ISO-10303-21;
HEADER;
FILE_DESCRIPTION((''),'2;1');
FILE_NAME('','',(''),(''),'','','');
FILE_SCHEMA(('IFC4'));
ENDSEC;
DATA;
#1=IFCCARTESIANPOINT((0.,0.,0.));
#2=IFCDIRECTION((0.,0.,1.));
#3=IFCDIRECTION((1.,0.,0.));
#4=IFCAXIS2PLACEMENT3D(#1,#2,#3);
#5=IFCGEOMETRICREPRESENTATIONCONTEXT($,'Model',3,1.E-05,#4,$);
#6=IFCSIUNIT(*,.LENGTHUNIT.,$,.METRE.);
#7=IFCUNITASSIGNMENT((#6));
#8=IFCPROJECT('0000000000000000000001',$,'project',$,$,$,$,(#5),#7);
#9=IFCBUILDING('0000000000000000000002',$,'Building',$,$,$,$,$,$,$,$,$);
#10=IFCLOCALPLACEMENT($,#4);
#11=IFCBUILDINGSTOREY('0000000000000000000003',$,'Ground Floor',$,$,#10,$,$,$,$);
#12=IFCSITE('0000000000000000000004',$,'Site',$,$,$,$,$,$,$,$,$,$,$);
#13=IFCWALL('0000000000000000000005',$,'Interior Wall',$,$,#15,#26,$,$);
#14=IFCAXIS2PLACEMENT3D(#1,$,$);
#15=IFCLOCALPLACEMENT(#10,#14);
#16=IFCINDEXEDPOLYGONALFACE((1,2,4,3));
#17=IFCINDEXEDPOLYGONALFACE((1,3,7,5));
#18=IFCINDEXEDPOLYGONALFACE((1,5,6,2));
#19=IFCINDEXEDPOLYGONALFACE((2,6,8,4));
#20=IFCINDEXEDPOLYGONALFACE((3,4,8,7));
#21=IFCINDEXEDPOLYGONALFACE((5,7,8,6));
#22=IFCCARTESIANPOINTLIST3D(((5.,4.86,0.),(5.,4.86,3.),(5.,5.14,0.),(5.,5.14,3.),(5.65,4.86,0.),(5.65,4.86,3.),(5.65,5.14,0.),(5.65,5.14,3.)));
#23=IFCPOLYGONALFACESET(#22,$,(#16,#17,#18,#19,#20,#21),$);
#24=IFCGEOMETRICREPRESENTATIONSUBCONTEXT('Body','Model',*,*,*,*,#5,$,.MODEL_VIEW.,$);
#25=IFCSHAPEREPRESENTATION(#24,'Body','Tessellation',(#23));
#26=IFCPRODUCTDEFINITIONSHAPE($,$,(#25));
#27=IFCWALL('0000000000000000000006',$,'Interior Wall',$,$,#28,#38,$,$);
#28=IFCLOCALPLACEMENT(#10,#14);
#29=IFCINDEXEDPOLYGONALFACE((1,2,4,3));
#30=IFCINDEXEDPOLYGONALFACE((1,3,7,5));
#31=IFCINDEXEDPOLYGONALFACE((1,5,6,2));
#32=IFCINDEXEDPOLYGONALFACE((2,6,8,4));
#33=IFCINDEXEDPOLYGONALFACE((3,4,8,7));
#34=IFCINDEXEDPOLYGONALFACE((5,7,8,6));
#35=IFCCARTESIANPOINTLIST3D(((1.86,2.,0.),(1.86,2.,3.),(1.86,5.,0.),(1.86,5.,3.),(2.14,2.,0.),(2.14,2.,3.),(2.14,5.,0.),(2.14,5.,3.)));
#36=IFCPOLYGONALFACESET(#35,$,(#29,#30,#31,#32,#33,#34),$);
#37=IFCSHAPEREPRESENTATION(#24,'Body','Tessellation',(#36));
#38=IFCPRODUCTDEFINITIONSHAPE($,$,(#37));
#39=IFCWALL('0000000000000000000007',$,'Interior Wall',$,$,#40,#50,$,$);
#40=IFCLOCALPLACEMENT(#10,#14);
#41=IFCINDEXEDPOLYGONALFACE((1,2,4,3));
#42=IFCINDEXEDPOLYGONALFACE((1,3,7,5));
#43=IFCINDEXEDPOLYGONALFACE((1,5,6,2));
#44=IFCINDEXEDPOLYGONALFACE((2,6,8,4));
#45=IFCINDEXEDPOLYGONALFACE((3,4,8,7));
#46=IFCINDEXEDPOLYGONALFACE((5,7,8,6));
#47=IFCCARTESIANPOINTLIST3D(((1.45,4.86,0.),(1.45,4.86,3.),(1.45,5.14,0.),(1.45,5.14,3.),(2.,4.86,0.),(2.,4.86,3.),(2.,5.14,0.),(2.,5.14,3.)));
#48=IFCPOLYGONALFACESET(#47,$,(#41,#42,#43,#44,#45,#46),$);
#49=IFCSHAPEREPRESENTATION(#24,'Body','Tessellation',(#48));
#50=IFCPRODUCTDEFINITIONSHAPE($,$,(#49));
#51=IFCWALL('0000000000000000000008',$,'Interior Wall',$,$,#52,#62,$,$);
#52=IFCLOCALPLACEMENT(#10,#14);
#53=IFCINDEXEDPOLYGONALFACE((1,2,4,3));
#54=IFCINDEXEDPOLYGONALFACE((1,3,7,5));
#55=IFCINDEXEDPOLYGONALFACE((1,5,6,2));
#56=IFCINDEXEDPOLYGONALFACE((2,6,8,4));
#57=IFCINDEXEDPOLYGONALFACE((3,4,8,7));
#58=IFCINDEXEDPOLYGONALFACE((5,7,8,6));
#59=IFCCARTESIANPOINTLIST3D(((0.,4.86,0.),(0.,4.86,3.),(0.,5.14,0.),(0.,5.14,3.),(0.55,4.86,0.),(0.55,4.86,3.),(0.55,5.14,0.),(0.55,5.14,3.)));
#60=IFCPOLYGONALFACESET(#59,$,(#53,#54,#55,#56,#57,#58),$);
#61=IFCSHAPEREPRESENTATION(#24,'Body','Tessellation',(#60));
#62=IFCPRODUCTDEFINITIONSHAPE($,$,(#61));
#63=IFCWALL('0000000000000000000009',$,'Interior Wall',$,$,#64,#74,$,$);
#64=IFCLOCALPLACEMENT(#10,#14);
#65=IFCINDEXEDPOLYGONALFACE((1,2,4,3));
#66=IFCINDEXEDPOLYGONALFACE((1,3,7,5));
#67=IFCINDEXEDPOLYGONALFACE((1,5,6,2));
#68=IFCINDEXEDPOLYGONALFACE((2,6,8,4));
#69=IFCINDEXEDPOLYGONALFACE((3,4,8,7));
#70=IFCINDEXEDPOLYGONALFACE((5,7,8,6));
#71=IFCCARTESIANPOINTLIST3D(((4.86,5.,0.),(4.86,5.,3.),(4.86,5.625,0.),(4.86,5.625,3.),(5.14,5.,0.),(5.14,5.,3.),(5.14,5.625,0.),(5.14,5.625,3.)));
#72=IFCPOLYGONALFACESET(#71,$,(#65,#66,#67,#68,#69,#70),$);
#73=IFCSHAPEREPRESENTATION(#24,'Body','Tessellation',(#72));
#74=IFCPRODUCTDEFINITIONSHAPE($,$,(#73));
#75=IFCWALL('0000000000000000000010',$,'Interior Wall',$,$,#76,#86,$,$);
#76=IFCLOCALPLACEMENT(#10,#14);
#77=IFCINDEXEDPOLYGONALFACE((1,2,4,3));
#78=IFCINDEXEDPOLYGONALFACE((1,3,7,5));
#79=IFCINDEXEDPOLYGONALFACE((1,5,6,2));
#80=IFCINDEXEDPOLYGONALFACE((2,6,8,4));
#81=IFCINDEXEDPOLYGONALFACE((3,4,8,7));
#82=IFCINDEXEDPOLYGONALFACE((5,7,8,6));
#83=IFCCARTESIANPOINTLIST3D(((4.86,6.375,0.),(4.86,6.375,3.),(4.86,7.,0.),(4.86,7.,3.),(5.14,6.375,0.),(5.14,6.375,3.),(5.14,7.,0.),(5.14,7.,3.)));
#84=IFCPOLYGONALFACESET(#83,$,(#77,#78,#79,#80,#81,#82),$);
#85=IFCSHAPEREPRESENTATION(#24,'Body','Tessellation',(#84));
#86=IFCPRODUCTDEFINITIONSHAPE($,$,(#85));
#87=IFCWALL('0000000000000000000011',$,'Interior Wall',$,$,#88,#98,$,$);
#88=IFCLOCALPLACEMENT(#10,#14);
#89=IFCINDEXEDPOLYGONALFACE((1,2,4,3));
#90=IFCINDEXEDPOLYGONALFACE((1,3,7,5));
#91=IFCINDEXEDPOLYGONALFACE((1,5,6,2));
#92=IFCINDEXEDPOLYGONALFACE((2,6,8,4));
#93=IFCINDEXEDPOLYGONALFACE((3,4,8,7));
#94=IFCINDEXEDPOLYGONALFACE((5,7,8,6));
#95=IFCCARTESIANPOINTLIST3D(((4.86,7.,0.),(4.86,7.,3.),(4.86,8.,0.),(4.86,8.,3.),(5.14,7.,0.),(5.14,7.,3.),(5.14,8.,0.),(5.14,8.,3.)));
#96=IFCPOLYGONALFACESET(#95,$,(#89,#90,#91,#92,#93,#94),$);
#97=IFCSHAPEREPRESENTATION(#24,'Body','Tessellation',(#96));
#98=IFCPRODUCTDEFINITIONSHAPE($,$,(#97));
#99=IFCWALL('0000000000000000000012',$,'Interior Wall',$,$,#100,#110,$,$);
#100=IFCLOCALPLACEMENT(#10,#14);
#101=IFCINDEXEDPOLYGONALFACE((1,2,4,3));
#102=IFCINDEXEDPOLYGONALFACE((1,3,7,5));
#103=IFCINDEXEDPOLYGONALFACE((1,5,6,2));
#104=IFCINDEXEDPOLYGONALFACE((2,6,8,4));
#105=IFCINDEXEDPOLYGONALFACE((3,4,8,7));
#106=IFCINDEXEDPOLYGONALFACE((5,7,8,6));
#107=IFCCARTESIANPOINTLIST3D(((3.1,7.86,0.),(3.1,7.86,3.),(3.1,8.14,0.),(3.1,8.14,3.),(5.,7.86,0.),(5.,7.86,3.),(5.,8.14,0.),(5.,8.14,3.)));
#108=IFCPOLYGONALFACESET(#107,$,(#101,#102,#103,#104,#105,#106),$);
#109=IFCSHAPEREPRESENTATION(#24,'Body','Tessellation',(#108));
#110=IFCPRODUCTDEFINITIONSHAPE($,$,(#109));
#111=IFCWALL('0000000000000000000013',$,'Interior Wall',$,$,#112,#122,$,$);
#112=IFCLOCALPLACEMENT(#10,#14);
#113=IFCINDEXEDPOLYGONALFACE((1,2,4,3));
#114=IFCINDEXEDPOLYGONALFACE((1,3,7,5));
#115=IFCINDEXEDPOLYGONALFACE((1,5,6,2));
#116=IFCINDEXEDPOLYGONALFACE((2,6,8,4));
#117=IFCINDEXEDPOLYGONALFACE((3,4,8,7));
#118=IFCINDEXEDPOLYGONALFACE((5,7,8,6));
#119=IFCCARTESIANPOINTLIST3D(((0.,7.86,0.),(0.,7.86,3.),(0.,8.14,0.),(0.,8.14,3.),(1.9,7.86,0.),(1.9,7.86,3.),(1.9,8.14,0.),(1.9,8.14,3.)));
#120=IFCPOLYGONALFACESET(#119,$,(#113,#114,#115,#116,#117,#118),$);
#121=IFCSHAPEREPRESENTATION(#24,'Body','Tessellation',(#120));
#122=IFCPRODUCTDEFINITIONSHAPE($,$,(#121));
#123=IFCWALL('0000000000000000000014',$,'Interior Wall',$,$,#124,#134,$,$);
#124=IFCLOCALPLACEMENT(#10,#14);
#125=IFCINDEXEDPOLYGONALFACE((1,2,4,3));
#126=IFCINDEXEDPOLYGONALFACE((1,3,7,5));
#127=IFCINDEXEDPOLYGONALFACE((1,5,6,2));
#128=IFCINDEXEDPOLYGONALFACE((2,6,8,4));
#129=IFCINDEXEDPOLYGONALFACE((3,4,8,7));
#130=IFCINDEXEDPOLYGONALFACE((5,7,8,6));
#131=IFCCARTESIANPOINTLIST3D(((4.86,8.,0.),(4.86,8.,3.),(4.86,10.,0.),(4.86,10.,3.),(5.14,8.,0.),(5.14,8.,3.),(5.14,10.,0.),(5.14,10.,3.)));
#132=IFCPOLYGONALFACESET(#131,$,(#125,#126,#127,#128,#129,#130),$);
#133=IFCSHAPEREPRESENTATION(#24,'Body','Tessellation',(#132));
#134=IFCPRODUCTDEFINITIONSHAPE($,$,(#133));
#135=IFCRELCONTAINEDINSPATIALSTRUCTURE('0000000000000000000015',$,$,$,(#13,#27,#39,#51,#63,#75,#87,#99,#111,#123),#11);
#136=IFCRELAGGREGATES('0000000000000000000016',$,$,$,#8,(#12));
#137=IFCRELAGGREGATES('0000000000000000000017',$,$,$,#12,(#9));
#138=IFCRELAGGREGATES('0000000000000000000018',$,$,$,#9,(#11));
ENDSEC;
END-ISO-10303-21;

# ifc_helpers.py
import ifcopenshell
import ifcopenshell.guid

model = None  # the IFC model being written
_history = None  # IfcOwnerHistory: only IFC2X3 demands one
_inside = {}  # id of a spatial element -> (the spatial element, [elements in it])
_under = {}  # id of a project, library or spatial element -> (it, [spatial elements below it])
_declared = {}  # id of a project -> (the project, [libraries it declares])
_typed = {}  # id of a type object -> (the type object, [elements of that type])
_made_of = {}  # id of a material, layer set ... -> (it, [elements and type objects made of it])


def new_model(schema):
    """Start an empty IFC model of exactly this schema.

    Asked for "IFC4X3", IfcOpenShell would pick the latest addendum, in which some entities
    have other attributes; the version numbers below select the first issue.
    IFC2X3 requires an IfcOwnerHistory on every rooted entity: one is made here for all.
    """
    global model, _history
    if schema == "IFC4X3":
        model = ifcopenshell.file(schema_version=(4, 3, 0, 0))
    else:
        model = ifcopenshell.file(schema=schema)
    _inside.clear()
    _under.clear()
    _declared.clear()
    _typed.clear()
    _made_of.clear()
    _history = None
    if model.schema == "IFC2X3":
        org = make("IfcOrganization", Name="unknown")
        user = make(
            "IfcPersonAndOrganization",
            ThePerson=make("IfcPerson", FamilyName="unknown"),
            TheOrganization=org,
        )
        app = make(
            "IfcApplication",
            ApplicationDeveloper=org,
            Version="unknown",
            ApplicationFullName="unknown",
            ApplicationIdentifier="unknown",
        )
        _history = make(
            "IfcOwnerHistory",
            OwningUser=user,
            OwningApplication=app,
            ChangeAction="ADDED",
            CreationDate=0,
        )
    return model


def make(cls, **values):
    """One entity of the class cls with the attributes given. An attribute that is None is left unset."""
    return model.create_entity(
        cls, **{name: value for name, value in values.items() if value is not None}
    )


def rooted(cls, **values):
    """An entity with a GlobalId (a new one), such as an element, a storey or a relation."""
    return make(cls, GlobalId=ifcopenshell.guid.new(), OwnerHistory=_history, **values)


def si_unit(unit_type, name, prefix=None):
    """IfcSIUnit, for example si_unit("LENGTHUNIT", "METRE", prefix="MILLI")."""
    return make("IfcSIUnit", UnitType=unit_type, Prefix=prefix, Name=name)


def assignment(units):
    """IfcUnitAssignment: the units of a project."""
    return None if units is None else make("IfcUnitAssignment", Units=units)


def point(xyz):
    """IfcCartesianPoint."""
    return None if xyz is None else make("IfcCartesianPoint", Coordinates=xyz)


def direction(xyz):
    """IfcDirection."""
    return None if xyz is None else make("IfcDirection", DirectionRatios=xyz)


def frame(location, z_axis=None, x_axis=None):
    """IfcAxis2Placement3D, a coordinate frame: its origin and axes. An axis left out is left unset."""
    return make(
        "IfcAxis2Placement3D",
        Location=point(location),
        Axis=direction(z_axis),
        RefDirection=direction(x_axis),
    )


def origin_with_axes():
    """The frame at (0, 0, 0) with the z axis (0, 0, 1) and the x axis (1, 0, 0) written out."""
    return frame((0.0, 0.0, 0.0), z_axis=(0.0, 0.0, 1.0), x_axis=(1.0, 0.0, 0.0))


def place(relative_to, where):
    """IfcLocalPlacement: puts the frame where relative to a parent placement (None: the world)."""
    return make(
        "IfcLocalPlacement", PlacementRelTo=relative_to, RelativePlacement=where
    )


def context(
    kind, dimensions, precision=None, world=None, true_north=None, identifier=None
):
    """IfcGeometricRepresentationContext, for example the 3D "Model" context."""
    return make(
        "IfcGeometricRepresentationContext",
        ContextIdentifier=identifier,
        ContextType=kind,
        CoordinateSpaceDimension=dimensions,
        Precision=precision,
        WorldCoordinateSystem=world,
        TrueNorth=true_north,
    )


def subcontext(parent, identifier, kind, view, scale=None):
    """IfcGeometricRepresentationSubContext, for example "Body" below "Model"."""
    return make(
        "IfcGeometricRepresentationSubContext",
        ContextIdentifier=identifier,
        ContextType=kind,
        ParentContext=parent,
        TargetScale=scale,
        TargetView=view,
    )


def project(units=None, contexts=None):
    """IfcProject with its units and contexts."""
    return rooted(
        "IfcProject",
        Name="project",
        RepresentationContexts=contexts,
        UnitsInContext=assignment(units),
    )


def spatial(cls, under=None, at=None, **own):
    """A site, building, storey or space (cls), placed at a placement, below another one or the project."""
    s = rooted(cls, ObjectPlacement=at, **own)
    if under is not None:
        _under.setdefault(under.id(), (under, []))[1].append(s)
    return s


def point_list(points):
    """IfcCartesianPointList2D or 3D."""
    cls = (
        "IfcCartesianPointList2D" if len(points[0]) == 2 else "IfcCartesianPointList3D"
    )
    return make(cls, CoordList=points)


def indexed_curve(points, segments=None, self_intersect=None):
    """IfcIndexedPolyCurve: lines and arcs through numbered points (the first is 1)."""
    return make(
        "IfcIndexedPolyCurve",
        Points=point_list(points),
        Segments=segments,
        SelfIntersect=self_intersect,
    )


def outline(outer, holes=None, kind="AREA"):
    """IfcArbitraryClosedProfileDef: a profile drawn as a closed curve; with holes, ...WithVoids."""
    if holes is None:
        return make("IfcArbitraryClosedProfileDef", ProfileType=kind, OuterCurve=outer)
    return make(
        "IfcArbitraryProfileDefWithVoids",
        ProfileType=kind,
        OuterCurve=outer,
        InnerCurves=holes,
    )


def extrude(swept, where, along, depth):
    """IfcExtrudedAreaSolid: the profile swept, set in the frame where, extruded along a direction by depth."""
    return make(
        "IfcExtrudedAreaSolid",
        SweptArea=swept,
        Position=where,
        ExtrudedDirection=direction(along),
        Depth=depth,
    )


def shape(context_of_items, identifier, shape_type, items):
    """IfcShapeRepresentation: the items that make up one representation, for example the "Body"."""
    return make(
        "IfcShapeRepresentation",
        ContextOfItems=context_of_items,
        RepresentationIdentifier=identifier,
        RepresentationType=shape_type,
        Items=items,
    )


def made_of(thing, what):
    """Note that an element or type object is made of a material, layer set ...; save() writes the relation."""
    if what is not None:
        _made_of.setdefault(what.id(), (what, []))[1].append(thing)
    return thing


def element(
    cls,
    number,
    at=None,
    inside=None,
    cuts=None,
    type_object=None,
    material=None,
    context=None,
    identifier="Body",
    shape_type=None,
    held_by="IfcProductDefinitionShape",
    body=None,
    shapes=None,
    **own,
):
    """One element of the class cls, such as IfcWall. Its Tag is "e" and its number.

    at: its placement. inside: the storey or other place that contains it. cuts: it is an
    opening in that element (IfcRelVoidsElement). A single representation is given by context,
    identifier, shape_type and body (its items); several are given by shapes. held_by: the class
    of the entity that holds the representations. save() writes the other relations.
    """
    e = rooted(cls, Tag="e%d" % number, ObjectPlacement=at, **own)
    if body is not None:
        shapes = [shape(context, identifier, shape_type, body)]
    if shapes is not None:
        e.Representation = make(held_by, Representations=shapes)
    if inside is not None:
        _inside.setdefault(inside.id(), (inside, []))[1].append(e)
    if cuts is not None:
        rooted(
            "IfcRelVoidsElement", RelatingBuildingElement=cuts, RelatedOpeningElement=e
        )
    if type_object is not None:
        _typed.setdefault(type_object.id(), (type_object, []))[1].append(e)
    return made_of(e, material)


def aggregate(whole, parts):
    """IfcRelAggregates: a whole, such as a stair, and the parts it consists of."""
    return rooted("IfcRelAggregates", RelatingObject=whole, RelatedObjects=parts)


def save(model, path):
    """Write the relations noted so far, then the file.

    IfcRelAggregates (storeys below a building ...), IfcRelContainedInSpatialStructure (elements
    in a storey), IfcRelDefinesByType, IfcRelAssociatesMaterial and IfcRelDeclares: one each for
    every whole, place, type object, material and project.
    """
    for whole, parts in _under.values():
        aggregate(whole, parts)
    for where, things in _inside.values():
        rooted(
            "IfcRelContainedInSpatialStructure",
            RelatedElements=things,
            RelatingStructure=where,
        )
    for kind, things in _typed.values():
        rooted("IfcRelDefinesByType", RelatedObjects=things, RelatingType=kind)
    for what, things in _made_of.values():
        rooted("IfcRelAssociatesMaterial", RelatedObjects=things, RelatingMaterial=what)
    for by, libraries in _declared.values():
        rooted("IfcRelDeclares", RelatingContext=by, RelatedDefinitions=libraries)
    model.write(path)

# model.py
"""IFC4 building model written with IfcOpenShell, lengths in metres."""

from ifc_helpers import new_model, si_unit, frame, origin_with_axes, place, context, subcontext, project, spatial, indexed_curve, outline, extrude, element, save


model = new_model("IFC4")

# Units and contexts
model_context = context("Model", 3, precision=1e-05, world=origin_with_axes())
body_context = subcontext(model_context, "Body", "Model", "MODEL_VIEW")
ifc_project = project(units=[si_unit("LENGTHUNIT", "METRE")], contexts=[model_context])

# Site, building, storey
site = spatial("IfcSite", under=ifc_project, Name="Site")
building = spatial("IfcBuilding", under=site, Name="Building")
storey_placement = place(None, origin_with_axes())
storey = spatial("IfcBuildingStorey", under=building, at=storey_placement, Name="Ground Floor")

# Walls
wall_1_placement = place(storey_placement, frame((5.65, 5.0, 0.0), z_axis=(0.0, 0.0, 1.0), x_axis=(-1.0, 0.0, 0.0)))
element("IfcWall", 1, at=wall_1_placement, inside=storey, Name="Interior Wall", context=body_context, shape_type="SweptSolid", body=[
    extrude(outline(indexed_curve([(0.0, 0.0), (0.0, 0.28), (0.65, 0.28), (0.65, 0.0), (0.0, 0.0)], self_intersect=False)), frame((0.0, -0.14, 0.0), z_axis=(0.0, 0.0, 1.0), x_axis=(1.0, 0.0, 0.0)), (0.0, 0.0, 1.0), 3.0),
])
wall_2_placement = place(storey_placement, frame((2.0, 5.0, 0.0), z_axis=(0.0, 0.0, 1.0), x_axis=(0.0, -1.0, 0.0)))
element("IfcWall", 2, at=wall_2_placement, inside=storey, Name="Interior Wall", context=body_context, shape_type="SweptSolid", body=[
    extrude(outline(indexed_curve([(0.0, 0.0), (0.0, 0.28), (3.0, 0.28), (3.0, 0.0), (0.0, 0.0)], self_intersect=False)), frame((0.0, -0.14, 0.0), z_axis=(0.0, 0.0, 1.0), x_axis=(1.0, 0.0, 0.0)), (0.0, 0.0, 1.0), 3.0),
])
for number, where, z_axis, x_axis, name in (
    (3, (2.0, 5.0, 0.0), (0.0, 0.0, 1.0), (-1.0, 0.0, 0.0), "Interior Wall"),
    (4, (0.55, 5.0, 0.0), (0.0, 0.0, 1.0), (-1.0, 0.0, 0.0), "Interior Wall"),
):
    element("IfcWall", number, at=place(storey_placement, frame(where, z_axis=z_axis, x_axis=x_axis)), inside=storey, Name=name, context=body_context, shape_type="SweptSolid", body=[
        extrude(outline(indexed_curve([(0.0, 0.0), (0.0, 0.28), (0.55, 0.28), (0.55, 0.0), (0.0, 0.0)], self_intersect=False)), frame((0.0, -0.14, 0.0), z_axis=(0.0, 0.0, 1.0), x_axis=(1.0, 0.0, 0.0)), (0.0, 0.0, 1.0), 3.0),
    ])
for number, where, z_axis, x_axis, name in (
    (5, (5.0, 5.0, 0.0), (0.0, 0.0, 1.0), (0.0, 1.0, 0.0), "Interior Wall"),
    (6, (5.0, 6.375, 0.0), (0.0, 0.0, 1.0), (0.0, 1.0, 0.0), "Interior Wall"),
):
    element("IfcWall", number, at=place(storey_placement, frame(where, z_axis=z_axis, x_axis=x_axis)), inside=storey, Name=name, context=body_context, shape_type="SweptSolid", body=[
        extrude(outline(indexed_curve([(0.0, 0.0), (0.0, 0.28), (0.625, 0.28), (0.625, 0.0), (0.0, 0.0)], self_intersect=False)), frame((0.0, -0.14, 0.0), z_axis=(0.0, 0.0, 1.0), x_axis=(1.0, 0.0, 0.0)), (0.0, 0.0, 1.0), 3.0),
    ])
wall_3_placement = place(storey_placement, frame((5.0, 7.0, 0.0), z_axis=(0.0, 0.0, 1.0), x_axis=(0.0, 1.0, 0.0)))
element("IfcWall", 7, at=wall_3_placement, inside=storey, Name="Interior Wall", context=body_context, shape_type="SweptSolid", body=[
    extrude(outline(indexed_curve([(0.0, 0.0), (0.0, 0.28), (1.0, 0.28), (1.0, 0.0), (0.0, 0.0)], self_intersect=False)), frame((0.0, -0.14, 0.0), z_axis=(0.0, 0.0, 1.0), x_axis=(1.0, 0.0, 0.0)), (0.0, 0.0, 1.0), 3.0),
])
for number, where, z_axis, x_axis, name in (
    (8, (5.0, 8.0, 0.0), (0.0, 0.0, 1.0), (-1.0, 0.0, 0.0), "Interior Wall"),
    (9, (1.9, 8.0, 0.0), (0.0, 0.0, 1.0), (-1.0, 0.0, 0.0), "Interior Wall"),
):
    element("IfcWall", number, at=place(storey_placement, frame(where, z_axis=z_axis, x_axis=x_axis)), inside=storey, Name=name, context=body_context, shape_type="SweptSolid", body=[
        extrude(outline(indexed_curve([(0.0, 0.0), (0.0, 0.28), (1.9, 0.28), (1.9, 0.0), (0.0, 0.0)], self_intersect=False)), frame((0.0, -0.14, 0.0), z_axis=(0.0, 0.0, 1.0), x_axis=(1.0, 0.0, 0.0)), (0.0, 0.0, 1.0), 3.0),
    ])
wall_4_placement = place(storey_placement, frame((5.0, 10.0, 0.0), z_axis=(0.0, 0.0, 1.0), x_axis=(0.0, -1.0, 0.0)))
element("IfcWall", 10, at=wall_4_placement, inside=storey, Name="Interior Wall", context=body_context, shape_type="SweptSolid", body=[
    extrude(outline(indexed_curve([(0.0, 0.0), (0.0, 0.28), (2.0, 0.28), (2.0, 0.0), (0.0, 0.0)], self_intersect=False)), frame((0.0, -0.14, 0.0), z_axis=(0.0, 0.0, 1.0), x_axis=(1.0, 0.0, 0.0)), (0.0, 0.0, 1.0), 3.0),
])

save(model, "model.ifc")
